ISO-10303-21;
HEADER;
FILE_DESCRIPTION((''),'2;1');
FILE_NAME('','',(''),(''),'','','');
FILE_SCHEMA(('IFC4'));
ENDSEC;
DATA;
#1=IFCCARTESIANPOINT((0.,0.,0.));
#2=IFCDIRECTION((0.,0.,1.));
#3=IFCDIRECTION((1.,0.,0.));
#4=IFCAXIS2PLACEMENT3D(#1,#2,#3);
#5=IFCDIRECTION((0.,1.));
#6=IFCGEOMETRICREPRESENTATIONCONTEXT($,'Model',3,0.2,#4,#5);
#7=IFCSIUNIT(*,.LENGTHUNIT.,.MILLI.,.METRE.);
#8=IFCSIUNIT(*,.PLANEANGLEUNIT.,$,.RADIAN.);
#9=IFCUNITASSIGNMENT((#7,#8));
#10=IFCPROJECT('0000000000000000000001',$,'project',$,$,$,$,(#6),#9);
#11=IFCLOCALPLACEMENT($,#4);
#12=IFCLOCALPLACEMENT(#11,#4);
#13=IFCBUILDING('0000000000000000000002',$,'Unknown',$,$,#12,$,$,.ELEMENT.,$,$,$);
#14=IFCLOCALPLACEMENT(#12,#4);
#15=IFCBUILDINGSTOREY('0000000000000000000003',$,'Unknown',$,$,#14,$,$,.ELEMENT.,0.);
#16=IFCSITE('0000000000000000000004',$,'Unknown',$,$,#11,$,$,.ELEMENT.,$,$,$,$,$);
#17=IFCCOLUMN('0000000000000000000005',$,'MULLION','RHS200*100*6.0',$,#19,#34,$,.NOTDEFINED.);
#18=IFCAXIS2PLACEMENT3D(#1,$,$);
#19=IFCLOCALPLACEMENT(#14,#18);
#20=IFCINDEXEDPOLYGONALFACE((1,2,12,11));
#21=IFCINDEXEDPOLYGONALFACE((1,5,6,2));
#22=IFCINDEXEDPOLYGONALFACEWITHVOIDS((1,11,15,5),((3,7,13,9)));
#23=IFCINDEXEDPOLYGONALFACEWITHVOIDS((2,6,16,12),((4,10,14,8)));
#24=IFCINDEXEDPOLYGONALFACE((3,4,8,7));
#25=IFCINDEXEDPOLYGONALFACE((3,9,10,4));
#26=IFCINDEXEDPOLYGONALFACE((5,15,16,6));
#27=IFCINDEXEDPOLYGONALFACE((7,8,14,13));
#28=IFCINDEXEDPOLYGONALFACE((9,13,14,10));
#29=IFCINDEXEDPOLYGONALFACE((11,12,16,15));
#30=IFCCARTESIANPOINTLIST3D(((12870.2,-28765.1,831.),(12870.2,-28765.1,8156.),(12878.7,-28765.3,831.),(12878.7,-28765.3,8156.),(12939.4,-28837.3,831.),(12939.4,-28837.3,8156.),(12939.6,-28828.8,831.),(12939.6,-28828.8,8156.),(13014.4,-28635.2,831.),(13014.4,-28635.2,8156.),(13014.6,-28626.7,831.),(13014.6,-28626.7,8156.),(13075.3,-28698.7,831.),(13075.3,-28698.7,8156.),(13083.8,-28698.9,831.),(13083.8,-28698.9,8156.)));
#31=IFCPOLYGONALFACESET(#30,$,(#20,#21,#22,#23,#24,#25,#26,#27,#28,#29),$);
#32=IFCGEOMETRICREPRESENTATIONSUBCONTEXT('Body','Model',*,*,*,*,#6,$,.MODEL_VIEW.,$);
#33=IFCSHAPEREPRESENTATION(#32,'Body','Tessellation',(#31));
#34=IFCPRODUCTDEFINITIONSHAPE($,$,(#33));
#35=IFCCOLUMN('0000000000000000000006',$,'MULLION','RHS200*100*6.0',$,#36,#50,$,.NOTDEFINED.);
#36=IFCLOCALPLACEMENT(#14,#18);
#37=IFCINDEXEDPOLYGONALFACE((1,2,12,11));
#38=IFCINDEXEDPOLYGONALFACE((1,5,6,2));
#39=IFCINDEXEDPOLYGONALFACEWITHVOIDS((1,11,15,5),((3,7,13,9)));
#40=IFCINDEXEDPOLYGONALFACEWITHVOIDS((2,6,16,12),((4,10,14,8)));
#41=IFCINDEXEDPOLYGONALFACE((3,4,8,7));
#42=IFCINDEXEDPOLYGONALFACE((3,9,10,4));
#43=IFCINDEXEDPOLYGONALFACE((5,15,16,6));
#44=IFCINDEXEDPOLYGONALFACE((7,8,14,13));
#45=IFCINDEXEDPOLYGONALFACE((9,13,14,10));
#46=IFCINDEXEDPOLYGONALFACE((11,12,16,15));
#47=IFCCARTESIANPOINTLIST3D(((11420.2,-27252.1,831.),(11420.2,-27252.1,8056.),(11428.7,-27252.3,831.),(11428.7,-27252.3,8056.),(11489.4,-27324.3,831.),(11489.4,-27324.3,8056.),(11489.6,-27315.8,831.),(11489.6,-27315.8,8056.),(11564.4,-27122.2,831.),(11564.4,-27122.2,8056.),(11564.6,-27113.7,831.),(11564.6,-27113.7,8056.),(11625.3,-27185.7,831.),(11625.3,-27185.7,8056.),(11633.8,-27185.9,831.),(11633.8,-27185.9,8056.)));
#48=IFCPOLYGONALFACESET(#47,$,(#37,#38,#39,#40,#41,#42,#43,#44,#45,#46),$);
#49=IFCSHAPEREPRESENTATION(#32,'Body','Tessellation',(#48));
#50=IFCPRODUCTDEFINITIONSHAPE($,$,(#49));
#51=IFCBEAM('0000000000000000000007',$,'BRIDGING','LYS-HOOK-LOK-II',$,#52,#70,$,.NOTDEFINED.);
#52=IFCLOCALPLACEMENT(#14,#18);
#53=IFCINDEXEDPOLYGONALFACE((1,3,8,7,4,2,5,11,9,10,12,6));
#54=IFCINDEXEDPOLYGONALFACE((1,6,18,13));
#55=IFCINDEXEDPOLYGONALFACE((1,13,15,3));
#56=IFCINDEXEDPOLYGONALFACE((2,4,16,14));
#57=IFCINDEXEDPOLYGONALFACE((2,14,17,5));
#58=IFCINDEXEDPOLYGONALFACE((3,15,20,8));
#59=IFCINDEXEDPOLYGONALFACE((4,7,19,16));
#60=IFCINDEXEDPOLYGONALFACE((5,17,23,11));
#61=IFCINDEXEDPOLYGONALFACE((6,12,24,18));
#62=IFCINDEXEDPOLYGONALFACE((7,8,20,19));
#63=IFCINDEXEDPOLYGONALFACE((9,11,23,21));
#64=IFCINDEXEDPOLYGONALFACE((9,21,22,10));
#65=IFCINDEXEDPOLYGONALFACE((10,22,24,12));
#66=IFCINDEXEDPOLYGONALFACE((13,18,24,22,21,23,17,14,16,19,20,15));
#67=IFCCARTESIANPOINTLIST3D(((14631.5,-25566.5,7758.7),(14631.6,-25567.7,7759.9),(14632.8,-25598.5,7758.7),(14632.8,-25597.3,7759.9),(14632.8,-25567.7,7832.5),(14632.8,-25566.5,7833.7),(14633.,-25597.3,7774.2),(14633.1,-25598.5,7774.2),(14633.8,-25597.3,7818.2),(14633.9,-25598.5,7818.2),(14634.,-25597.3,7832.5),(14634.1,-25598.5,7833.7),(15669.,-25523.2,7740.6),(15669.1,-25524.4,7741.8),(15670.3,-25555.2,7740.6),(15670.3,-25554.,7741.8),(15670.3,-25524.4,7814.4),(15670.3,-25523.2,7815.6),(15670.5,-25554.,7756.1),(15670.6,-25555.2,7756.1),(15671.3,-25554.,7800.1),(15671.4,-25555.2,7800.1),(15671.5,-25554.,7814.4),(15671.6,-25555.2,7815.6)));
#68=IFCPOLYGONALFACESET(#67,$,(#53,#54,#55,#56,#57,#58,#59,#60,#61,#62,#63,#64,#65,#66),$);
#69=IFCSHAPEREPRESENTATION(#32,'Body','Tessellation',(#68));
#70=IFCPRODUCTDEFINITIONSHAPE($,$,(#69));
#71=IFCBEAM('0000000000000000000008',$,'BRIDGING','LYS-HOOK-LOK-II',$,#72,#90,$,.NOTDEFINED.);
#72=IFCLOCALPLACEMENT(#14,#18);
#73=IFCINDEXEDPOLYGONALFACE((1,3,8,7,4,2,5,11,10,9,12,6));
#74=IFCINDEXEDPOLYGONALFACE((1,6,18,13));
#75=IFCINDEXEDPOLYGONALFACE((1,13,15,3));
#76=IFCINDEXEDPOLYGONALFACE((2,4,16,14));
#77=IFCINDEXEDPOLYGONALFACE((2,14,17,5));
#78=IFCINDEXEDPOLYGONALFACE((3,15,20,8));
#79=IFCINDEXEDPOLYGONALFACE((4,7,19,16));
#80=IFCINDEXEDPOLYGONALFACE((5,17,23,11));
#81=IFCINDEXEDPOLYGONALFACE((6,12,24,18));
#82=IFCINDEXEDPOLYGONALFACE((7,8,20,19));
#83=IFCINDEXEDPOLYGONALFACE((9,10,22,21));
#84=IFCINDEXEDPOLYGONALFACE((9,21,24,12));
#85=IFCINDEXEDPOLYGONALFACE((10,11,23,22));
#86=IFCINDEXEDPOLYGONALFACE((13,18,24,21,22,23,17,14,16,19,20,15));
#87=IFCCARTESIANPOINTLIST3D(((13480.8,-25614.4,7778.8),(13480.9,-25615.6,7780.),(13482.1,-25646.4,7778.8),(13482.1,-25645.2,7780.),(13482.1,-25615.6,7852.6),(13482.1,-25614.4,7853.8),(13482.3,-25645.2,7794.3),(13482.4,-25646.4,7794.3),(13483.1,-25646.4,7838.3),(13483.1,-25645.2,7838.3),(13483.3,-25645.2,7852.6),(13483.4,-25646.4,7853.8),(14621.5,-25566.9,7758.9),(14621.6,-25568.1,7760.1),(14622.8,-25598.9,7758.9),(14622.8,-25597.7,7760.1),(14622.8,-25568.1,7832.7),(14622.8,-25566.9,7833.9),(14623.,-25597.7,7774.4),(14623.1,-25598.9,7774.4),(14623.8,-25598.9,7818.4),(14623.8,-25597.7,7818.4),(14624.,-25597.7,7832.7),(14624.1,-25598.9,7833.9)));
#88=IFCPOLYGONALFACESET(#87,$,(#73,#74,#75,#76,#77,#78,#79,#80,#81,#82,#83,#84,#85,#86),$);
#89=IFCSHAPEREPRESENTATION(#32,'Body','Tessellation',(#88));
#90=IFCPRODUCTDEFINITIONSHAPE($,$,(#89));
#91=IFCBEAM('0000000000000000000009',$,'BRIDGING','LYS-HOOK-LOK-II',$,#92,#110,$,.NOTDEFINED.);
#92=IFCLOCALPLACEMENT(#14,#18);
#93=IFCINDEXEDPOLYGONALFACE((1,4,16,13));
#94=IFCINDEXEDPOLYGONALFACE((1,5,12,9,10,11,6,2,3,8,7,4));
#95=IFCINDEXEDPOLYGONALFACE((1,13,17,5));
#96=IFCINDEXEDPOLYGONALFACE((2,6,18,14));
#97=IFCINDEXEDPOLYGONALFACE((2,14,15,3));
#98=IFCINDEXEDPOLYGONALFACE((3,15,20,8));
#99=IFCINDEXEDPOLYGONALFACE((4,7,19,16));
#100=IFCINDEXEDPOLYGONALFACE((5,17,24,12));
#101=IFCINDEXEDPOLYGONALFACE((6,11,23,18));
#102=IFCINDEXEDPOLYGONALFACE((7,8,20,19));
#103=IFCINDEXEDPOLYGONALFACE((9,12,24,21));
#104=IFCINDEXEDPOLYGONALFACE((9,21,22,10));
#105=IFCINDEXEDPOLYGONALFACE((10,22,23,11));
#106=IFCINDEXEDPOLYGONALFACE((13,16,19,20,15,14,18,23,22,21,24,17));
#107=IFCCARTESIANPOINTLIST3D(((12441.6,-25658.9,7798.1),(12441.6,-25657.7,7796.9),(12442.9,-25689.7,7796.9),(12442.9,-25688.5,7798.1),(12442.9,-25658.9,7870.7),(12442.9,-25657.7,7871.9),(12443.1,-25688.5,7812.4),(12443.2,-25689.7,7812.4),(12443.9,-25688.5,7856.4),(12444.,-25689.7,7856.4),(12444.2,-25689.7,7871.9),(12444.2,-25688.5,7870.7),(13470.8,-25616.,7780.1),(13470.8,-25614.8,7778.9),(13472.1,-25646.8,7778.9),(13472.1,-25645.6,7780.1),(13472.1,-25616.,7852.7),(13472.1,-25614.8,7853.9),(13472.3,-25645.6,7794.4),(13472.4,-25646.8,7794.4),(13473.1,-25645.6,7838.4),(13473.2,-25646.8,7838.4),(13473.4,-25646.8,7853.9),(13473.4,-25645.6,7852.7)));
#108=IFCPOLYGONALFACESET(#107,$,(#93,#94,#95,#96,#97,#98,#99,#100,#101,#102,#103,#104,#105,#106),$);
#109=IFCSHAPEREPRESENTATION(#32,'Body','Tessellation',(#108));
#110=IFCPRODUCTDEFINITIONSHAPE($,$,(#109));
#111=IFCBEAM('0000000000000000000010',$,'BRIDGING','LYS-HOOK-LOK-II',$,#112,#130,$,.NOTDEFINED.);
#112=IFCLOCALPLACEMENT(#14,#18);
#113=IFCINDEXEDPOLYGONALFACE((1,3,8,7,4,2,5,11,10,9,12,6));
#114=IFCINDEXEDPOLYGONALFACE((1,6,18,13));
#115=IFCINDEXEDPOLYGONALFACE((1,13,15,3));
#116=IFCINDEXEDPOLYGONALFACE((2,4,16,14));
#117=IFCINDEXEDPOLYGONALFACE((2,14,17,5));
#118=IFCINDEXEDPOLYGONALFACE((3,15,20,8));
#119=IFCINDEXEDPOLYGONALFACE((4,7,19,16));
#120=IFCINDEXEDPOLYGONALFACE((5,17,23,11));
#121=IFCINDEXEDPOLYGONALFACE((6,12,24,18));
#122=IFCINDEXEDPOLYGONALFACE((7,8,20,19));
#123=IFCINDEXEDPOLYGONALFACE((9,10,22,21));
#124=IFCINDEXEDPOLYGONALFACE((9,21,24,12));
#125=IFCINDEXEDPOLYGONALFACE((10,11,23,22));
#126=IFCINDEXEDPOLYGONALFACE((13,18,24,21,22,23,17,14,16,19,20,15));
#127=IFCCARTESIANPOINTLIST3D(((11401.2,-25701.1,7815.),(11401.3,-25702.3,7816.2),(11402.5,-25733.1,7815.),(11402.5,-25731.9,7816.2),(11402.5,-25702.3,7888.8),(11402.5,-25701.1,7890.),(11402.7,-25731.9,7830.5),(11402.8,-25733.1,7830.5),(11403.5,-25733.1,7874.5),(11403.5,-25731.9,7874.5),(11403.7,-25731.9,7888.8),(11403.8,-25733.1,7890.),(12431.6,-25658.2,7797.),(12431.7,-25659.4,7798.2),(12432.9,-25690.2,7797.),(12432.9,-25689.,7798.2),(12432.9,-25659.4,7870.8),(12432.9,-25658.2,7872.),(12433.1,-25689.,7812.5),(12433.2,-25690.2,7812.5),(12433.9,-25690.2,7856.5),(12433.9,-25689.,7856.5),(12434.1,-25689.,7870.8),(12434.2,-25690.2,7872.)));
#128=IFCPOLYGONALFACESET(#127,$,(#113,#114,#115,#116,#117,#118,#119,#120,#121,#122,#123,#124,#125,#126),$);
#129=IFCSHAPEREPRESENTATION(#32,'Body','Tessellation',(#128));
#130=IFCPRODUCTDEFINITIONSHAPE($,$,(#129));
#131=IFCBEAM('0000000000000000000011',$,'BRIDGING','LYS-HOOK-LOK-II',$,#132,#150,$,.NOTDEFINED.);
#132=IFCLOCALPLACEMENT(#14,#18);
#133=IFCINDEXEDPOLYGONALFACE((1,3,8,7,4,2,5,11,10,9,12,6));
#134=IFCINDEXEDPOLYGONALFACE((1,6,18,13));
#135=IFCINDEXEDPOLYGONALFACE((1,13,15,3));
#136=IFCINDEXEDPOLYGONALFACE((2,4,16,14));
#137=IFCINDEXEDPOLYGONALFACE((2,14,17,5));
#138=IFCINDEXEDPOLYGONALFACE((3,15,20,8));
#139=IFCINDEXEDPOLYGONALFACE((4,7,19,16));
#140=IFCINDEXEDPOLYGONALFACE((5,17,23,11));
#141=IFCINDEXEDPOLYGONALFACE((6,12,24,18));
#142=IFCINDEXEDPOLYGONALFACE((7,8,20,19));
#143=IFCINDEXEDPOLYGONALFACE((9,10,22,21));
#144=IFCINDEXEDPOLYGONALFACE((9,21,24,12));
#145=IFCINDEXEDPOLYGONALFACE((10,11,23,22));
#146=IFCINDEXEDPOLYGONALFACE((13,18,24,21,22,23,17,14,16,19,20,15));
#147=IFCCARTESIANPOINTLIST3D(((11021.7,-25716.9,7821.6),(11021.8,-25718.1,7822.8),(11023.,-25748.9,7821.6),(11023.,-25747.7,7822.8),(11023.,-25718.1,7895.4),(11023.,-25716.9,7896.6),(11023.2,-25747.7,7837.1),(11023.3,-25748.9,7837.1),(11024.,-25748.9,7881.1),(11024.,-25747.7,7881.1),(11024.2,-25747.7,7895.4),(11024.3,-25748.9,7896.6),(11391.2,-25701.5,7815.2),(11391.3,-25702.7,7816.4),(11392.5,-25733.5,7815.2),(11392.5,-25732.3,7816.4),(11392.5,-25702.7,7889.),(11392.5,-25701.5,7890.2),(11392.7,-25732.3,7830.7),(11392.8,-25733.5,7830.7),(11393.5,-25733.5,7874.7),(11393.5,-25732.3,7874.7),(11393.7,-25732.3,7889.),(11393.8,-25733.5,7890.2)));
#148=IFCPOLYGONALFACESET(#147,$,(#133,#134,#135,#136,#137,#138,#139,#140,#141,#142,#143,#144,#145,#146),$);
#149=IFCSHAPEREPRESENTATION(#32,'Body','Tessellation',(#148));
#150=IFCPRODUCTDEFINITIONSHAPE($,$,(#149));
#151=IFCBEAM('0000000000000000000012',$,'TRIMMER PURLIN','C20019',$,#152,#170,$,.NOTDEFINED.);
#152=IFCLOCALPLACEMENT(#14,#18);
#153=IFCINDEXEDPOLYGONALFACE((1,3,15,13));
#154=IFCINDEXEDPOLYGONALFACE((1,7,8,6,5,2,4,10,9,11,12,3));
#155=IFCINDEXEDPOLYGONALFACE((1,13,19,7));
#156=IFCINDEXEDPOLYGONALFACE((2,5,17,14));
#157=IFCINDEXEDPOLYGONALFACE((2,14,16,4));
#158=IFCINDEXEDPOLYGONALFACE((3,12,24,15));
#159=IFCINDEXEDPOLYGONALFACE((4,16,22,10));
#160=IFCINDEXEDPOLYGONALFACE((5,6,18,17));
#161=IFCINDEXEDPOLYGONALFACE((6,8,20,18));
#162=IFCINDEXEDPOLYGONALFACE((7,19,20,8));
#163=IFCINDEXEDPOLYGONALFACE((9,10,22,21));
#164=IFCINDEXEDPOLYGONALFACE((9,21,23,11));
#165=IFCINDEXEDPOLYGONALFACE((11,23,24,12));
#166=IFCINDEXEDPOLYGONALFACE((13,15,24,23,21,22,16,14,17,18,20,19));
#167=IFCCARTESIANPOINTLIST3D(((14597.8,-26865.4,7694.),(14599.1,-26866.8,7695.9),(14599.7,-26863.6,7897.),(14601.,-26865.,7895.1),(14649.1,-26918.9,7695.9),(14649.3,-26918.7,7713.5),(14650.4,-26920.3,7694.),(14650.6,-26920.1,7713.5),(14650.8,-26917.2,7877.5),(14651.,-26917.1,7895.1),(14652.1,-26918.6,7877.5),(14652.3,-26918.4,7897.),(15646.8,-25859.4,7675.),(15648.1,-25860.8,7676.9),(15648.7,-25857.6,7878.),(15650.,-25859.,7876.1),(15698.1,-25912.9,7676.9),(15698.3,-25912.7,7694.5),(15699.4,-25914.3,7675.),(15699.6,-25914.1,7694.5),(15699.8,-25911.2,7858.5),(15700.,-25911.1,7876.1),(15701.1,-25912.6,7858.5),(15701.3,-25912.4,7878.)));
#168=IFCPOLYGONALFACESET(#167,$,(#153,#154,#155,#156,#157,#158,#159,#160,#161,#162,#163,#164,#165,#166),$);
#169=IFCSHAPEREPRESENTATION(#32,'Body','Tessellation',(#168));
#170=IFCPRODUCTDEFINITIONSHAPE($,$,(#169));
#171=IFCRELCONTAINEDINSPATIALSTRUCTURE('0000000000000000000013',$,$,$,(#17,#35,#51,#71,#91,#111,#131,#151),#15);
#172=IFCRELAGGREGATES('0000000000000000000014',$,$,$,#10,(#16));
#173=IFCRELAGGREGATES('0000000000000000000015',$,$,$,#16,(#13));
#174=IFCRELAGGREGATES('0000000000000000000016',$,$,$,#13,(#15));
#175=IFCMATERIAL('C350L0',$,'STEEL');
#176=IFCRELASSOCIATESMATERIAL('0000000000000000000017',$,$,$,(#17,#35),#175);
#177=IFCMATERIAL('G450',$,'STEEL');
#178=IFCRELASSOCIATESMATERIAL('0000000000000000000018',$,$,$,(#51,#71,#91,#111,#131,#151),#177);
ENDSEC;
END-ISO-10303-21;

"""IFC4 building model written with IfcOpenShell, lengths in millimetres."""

from ifc_helpers import new_model, si_unit, direction, frame, origin_with_axes, place, context, subcontext, project, spatial, line, indexed_curve, outline, extrude, material, element, save


model = new_model("IFC4")

# Units and contexts
model_context = context("Model", 3, precision=0.2, world=origin_with_axes(), true_north=direction((0.0, 1.0)))
body_context = subcontext(model_context, "Body", "Model", "MODEL_VIEW")
ifc_project = project(units=[si_unit("LENGTHUNIT", "METRE", prefix="MILLI"), si_unit("PLANEANGLEUNIT", "RADIAN")], contexts=[model_context])

# Site, building, storey
site_placement = place(None, origin_with_axes())
site = spatial("IfcSite", under=ifc_project, at=site_placement, Name="Unknown", CompositionType="ELEMENT")
building_placement = place(site_placement, origin_with_axes())
building = spatial("IfcBuilding", under=site, at=building_placement, Name="Unknown", CompositionType="ELEMENT")
storey_placement = place(building_placement, origin_with_axes())
storey = spatial("IfcBuildingStorey", under=building, at=storey_placement, Name="Unknown", CompositionType="ELEMENT", Elevation=0.0)

# Columns
ifc_material_1 = material(Name="C350L0", Category="STEEL")
column_1_placement = place(storey_placement, frame((12977.0, -28732.0, 831.0), z_axis=(0.691765, -0.722123, 0.0), x_axis=(0.0, 0.0, 1.0)))
element("IfcColumn", 1, at=column_1_placement, inside=storey, material=ifc_material_1, Name="MULLION", Description="RHS200*100*6.0", PredefinedType="NOTDEFINED", context=body_context, shape_type="SolidModel", body=[
    extrude(outline(indexed_curve([(-50.0, -100.0), (50.0, -100.0), (50.0, 100.0), (-50.0, 100.0)], segments=[line(1, 2, 3, 4, 1)]), holes=[indexed_curve([(-44.0, -94.0), (-44.0, 94.0), (44.0, 94.0), (44.0, -94.0)], segments=[line(1, 2, 3, 4, 1)])]), frame((0.0, 0.0, 0.0), z_axis=(-1.0, 0.0, 0.0), x_axis=(0.0, 0.0, 1.0)), (0.0, 0.0, -1.0), 7325.0),
])
column_2_placement = place(storey_placement, frame((11527.0, -27219.0, 831.0), z_axis=(0.691891, -0.722002, 0.0), x_axis=(0.0, 0.0, 1.0)))
element("IfcColumn", 2, at=column_2_placement, inside=storey, material=ifc_material_1, Name="MULLION", Description="RHS200*100*6.0", PredefinedType="NOTDEFINED", context=body_context, shape_type="SolidModel", body=[
    extrude(outline(indexed_curve([(-50.0, -100.0), (50.0, -100.0), (50.0, 100.0), (-50.0, 100.0)], segments=[line(1, 2, 3, 4, 1)]), holes=[indexed_curve([(-44.0, -94.0), (-44.0, 94.0), (44.0, 94.0), (44.0, -94.0)], segments=[line(1, 2, 3, 4, 1)])]), frame((0.0, 0.0, 0.0), z_axis=(-1.0, 0.0, 0.0), x_axis=(0.0, 0.0, 1.0)), (0.0, 0.0, -1.0), 7225.0),
])

# Beams
ifc_material_2 = material(Name="G450", Category="STEEL")
beam_1_placement = place(storey_placement, frame((14632.8, -25582.5, 7796.2), z_axis=(0.041699, -0.99913, 0.0), x_axis=(0.998978, 0.041692, -0.017428)))
element("IfcBeam", 3, at=beam_1_placement, inside=storey, material=ifc_material_2, Name="BRIDGING", Description="LYS-HOOK-LOK-II", PredefinedType="NOTDEFINED", context=body_context, shape_type="SolidModel", body=[
    extrude(outline(indexed_curve([(16.0, -37.5), (16.0, -22.0), (14.8, -22.0), (14.8, -36.3), (-14.8, -36.3), (-14.8, 36.3), (14.8, 36.3), (14.8, 22.0), (16.0, 22.0), (16.0, 37.5), (-16.0, 37.5), (-16.0, -37.5)], segments=[line(1, 2, 3, 4, 5, 6, 7, 8, 9, 10, 11, 12, 1)])), frame((0.0, 0.0, 0.0), z_axis=(-1.0, 0.0, 0.0), x_axis=(0.0, 0.0, 1.0)), (0.0, 0.0, -1.0), 1038.6),
])
beam_2_placement = place(storey_placement, frame((13482.1, -25630.4, 7816.3), z_axis=(0.041605, -0.999134, 0.0), x_axis=(0.998982, 0.041599, -0.017428)))
element("IfcBeam", 4, at=beam_2_placement, inside=storey, material=ifc_material_2, Name="BRIDGING", Description="LYS-HOOK-LOK-II", PredefinedType="NOTDEFINED", context=body_context, shape_type="SolidModel", body=[
    extrude(outline(indexed_curve([(16.0, -37.5), (16.0, -22.0), (14.8, -22.0), (14.8, -36.3), (-14.8, -36.3), (-14.8, 36.3), (14.8, 36.3), (14.8, 22.0), (16.0, 22.0), (16.0, 37.5), (-16.0, 37.5), (-16.0, -37.5)], segments=[line(1, 2, 3, 4, 5, 6, 7, 8, 9, 10, 11, 12, 1)])), frame((0.0, 0.0, 0.0), z_axis=(-1.0, 0.0, 0.0), x_axis=(0.0, 0.0, 1.0)), (0.0, 0.0, -1.0), 1141.9),
])
beam_3_placement = place(storey_placement, frame((12442.9, -25673.7, 7834.4), z_axis=(0.041647, -0.999132, 0.0), x_axis=(0.99898, 0.04164, -0.017471)))
element("IfcBeam", 5, at=beam_3_placement, inside=storey, material=ifc_material_2, Name="BRIDGING", Description="LYS-HOOK-LOK-II", PredefinedType="NOTDEFINED", context=body_context, shape_type="SolidModel", body=[
    extrude(outline(indexed_curve([(16.0, -37.5), (16.0, -22.0), (14.8, -22.0), (14.8, -36.3), (-14.8, -36.3), (-14.8, 36.3), (14.8, 36.3), (14.8, 22.0), (16.0, 22.0), (16.0, 37.5), (-16.0, 37.5), (-16.0, -37.5)], segments=[line(1, 2, 3, 4, 5, 6, 7, 8, 9, 10, 11, 12, 1)])), frame((0.0, 0.0, 0.0), z_axis=(-1.0, 0.0, 0.0), x_axis=(0.0, 0.0, 1.0)), (0.0, 0.0, -1.0), 1030.3),
])
beam_4_placement = place(storey_placement, frame((11402.5, -25717.1, 7852.5), z_axis=(0.041598, -0.999134, 0.0), x_axis=(0.998982, 0.041592, -0.017451)))
element("IfcBeam", 6, at=beam_4_placement, inside=storey, material=ifc_material_2, Name="BRIDGING", Description="LYS-HOOK-LOK-II", PredefinedType="NOTDEFINED", context=body_context, shape_type="SolidModel", body=[
    extrude(outline(indexed_curve([(16.0, -37.5), (16.0, -22.0), (14.8, -22.0), (14.8, -36.3), (-14.8, -36.3), (-14.8, 36.3), (14.8, 36.3), (14.8, 22.0), (16.0, 22.0), (16.0, 37.5), (-16.0, 37.5), (-16.0, -37.5)], segments=[line(1, 2, 3, 4, 5, 6, 7, 8, 9, 10, 11, 12, 1)])), frame((0.0, 0.0, 0.0), z_axis=(-1.0, 0.0, 0.0), x_axis=(0.0, 0.0, 1.0)), (0.0, 0.0, -1.0), 1031.4),
])
beam_5_placement = place(storey_placement, frame((11023.0, -25732.9, 7859.1), z_axis=(0.041642, -0.999133, 0.0), x_axis=(0.998983, 0.041636, -0.017303)))
element("IfcBeam", 7, at=beam_5_placement, inside=storey, material=ifc_material_2, Name="BRIDGING", Description="LYS-HOOK-LOK-II", PredefinedType="NOTDEFINED", context=body_context, shape_type="SolidModel", body=[
    extrude(outline(indexed_curve([(16.0, -37.5), (16.0, -22.0), (14.8, -22.0), (14.8, -36.3), (-14.8, -36.3), (-14.8, 36.3), (14.8, 36.3), (14.8, 22.0), (16.0, 22.0), (16.0, 37.5), (-16.0, 37.5), (-16.0, -37.5)], segments=[line(1, 2, 3, 4, 5, 6, 7, 8, 9, 10, 11, 12, 1)])), frame((0.0, 0.0, 0.0), z_axis=(-1.0, 0.0, 0.0), x_axis=(0.0, 0.0, 1.0)), (0.0, 0.0, -1.0), 369.9),
])
beam_6_placement = place(storey_placement, frame((14625.0, -26891.9, 7795.5), z_axis=(0.692159, -0.721745, 0.0), x_axis=(0.721683, 0.6921, -0.013071)))
element("IfcBeam", 8, at=beam_6_placement, inside=storey, material=ifc_material_2, Name="TRIMMER PURLIN", Description="C20019", PredefinedType="NOTDEFINED", context=body_context, shape_type="SolidModel", body=[
    extrude(outline(indexed_curve([(38.0, -101.5), (38.0, -82.0), (36.1, -82.0), (36.1, -99.6), (-36.1, -99.6), (-36.1, 99.6), (36.1, 99.6), (36.1, 82.0), (38.0, 82.0), (38.0, 101.5), (-38.0, 101.5), (-38.0, -101.5)], segments=[line(1, 2, 3, 4, 5, 6, 7, 8, 9, 10, 11, 12, 1)])), frame((0.0, 0.0, 0.0), z_axis=(-1.0, 0.0, 0.0), x_axis=(0.0, 0.0, 1.0)), (0.0, 0.0, -1.0), 1453.5),
])

save(model, "model.ifc")
